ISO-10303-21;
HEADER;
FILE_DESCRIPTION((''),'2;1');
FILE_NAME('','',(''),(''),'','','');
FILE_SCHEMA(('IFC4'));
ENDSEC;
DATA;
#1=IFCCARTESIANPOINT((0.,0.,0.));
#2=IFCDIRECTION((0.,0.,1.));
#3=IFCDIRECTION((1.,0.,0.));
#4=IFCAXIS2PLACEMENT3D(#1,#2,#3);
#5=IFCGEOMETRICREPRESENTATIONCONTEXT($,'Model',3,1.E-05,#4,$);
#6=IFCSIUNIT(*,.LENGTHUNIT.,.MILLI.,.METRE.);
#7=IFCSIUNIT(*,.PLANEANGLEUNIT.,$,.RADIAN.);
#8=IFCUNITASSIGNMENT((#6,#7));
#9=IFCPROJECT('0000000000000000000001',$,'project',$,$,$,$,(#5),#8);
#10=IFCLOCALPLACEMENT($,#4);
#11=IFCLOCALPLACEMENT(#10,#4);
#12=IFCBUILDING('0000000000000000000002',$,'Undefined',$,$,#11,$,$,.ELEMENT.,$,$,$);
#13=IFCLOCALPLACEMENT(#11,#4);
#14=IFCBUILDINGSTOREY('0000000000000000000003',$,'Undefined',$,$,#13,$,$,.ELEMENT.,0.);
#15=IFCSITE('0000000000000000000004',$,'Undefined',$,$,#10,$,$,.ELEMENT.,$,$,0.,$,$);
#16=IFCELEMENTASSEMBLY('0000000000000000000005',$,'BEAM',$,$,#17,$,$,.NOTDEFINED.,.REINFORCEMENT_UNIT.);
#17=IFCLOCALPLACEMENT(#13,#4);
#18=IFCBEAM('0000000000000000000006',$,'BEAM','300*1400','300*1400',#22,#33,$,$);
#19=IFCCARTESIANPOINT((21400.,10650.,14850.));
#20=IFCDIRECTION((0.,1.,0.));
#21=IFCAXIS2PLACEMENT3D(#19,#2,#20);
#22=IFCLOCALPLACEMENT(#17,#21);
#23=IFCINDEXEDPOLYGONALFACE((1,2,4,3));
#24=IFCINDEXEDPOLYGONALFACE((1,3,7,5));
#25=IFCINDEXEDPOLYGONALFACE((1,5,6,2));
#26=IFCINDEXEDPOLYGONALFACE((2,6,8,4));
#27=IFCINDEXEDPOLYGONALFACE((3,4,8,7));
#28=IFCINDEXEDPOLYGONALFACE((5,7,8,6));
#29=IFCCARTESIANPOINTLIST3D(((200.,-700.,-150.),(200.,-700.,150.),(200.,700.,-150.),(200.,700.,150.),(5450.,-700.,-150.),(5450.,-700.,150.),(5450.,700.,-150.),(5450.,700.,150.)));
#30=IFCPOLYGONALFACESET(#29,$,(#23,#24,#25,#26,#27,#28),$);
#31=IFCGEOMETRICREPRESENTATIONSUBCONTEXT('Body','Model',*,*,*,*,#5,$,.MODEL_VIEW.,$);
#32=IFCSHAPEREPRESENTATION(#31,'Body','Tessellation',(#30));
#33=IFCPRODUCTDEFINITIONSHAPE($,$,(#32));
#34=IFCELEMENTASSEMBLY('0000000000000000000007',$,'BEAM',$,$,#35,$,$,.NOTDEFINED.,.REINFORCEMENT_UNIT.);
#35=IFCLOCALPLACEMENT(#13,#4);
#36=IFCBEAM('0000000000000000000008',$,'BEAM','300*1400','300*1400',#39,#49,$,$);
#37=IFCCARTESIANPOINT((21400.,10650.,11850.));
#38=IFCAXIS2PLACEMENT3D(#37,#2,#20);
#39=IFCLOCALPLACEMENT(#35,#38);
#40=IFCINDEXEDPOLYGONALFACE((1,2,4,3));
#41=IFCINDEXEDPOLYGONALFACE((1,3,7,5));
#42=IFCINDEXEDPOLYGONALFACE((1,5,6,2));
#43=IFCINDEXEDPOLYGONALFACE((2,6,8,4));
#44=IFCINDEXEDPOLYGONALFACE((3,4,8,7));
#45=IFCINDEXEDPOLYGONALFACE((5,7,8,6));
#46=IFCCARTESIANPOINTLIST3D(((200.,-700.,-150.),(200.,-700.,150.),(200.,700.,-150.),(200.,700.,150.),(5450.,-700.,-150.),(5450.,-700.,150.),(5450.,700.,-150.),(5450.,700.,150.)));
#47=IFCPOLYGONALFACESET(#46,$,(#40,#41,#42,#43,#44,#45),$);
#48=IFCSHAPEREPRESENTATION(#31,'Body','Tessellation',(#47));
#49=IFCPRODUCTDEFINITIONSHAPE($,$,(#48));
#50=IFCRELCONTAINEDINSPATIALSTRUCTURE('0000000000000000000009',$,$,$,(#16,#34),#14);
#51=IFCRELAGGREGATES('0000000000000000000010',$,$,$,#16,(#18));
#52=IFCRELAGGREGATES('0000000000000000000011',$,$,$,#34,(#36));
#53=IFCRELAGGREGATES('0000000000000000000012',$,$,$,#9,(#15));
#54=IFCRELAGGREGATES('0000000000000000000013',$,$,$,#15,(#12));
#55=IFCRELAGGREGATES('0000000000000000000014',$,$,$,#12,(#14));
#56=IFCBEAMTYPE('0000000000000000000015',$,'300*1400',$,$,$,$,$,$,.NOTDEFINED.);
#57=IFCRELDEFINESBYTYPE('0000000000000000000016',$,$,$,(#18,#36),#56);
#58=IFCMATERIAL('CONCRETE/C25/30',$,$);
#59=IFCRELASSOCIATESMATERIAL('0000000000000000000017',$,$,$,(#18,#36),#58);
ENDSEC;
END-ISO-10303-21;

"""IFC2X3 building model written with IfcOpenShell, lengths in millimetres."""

from ifc_helpers import new_model, si_unit, frame, origin_with_axes, origin_2d_with_axis, place, context, subcontext, project, spatial, rectangle, extrude, material, type_object, element, aggregate, save


model = new_model("IFC2X3")

# Units and contexts
model_context = context("Model", 3, precision=1e-05, world=origin_with_axes())
body_context = subcontext(model_context, "Body", "Model", "MODEL_VIEW")
ifc_project = project(units=[si_unit("LENGTHUNIT", "METRE", prefix="MILLI"), si_unit("PLANEANGLEUNIT", "RADIAN")], contexts=[model_context])

# Site, building, storey
site_placement = place(None, origin_with_axes())
site = spatial("IfcSite", under=ifc_project, at=site_placement, Name="Undefined", CompositionType="ELEMENT", RefElevation=0.0)
building_placement = place(site_placement, origin_with_axes())
building = spatial("IfcBuilding", under=site, at=building_placement, Name="Undefined", CompositionType="ELEMENT")
storey_placement = place(building_placement, origin_with_axes())
storey = spatial("IfcBuildingStorey", under=building, at=storey_placement, Name="Undefined", CompositionType="ELEMENT", Elevation=0.0)

# Shared definitions
ifc_material = material(Name="CONCRETE/C25/30")

# Element assemblies, beams
beam_type_1 = type_object("IfcBeamType", Name="300*1400", PredefinedType="NOTDEFINED")
assembly_1_placement = place(storey_placement, origin_with_axes())
assembly_1 = element("IfcElementAssembly", 1, at=assembly_1_placement, inside=storey, Name="BEAM", AssemblyPlace="NOTDEFINED", PredefinedType="REINFORCEMENT_UNIT")
beam_1_placement = place(assembly_1_placement, frame((21400.0, 10650.0, 14850.0), z_axis=(0.0, 0.0, 1.0), x_axis=(0.0, 1.0, 0.0)))
beam_1 = element("IfcBeam", 2, at=beam_1_placement, type_object=beam_type_1, material=ifc_material, Name="BEAM", Description="300*1400", ObjectType="300*1400", context=body_context, shape_type="SweptSolid", body=[
    extrude(rectangle(XDim=1400.0, YDim=300.0, at=origin_2d_with_axis()), frame((5450.0, 0.0, 0.0), z_axis=(-1.0, 0.0, 0.0), x_axis=(0.0, -1.0, 0.0)), (0.0, 0.0, 1.0), 5250.0),
])
aggregate(assembly_1, [beam_1])
assembly_2_placement = place(storey_placement, origin_with_axes())
assembly_2 = element("IfcElementAssembly", 3, at=assembly_2_placement, inside=storey, Name="BEAM", AssemblyPlace="NOTDEFINED", PredefinedType="REINFORCEMENT_UNIT")
beam_2_placement = place(assembly_2_placement, frame((21400.0, 10650.0, 11850.0), z_axis=(0.0, 0.0, 1.0), x_axis=(0.0, 1.0, 0.0)))
beam_2 = element("IfcBeam", 4, at=beam_2_placement, type_object=beam_type_1, material=ifc_material, Name="BEAM", Description="300*1400", ObjectType="300*1400", context=body_context, shape_type="SweptSolid", body=[
    extrude(rectangle(XDim=1400.0, YDim=300.0, at=origin_2d_with_axis()), frame((5450.0, 0.0, 0.0), z_axis=(-1.0, 0.0, 0.0), x_axis=(0.0, -1.0, 0.0)), (0.0, 0.0, 1.0), 5250.0),
])
aggregate(assembly_2, [beam_2])

save(model, "model.ifc")
